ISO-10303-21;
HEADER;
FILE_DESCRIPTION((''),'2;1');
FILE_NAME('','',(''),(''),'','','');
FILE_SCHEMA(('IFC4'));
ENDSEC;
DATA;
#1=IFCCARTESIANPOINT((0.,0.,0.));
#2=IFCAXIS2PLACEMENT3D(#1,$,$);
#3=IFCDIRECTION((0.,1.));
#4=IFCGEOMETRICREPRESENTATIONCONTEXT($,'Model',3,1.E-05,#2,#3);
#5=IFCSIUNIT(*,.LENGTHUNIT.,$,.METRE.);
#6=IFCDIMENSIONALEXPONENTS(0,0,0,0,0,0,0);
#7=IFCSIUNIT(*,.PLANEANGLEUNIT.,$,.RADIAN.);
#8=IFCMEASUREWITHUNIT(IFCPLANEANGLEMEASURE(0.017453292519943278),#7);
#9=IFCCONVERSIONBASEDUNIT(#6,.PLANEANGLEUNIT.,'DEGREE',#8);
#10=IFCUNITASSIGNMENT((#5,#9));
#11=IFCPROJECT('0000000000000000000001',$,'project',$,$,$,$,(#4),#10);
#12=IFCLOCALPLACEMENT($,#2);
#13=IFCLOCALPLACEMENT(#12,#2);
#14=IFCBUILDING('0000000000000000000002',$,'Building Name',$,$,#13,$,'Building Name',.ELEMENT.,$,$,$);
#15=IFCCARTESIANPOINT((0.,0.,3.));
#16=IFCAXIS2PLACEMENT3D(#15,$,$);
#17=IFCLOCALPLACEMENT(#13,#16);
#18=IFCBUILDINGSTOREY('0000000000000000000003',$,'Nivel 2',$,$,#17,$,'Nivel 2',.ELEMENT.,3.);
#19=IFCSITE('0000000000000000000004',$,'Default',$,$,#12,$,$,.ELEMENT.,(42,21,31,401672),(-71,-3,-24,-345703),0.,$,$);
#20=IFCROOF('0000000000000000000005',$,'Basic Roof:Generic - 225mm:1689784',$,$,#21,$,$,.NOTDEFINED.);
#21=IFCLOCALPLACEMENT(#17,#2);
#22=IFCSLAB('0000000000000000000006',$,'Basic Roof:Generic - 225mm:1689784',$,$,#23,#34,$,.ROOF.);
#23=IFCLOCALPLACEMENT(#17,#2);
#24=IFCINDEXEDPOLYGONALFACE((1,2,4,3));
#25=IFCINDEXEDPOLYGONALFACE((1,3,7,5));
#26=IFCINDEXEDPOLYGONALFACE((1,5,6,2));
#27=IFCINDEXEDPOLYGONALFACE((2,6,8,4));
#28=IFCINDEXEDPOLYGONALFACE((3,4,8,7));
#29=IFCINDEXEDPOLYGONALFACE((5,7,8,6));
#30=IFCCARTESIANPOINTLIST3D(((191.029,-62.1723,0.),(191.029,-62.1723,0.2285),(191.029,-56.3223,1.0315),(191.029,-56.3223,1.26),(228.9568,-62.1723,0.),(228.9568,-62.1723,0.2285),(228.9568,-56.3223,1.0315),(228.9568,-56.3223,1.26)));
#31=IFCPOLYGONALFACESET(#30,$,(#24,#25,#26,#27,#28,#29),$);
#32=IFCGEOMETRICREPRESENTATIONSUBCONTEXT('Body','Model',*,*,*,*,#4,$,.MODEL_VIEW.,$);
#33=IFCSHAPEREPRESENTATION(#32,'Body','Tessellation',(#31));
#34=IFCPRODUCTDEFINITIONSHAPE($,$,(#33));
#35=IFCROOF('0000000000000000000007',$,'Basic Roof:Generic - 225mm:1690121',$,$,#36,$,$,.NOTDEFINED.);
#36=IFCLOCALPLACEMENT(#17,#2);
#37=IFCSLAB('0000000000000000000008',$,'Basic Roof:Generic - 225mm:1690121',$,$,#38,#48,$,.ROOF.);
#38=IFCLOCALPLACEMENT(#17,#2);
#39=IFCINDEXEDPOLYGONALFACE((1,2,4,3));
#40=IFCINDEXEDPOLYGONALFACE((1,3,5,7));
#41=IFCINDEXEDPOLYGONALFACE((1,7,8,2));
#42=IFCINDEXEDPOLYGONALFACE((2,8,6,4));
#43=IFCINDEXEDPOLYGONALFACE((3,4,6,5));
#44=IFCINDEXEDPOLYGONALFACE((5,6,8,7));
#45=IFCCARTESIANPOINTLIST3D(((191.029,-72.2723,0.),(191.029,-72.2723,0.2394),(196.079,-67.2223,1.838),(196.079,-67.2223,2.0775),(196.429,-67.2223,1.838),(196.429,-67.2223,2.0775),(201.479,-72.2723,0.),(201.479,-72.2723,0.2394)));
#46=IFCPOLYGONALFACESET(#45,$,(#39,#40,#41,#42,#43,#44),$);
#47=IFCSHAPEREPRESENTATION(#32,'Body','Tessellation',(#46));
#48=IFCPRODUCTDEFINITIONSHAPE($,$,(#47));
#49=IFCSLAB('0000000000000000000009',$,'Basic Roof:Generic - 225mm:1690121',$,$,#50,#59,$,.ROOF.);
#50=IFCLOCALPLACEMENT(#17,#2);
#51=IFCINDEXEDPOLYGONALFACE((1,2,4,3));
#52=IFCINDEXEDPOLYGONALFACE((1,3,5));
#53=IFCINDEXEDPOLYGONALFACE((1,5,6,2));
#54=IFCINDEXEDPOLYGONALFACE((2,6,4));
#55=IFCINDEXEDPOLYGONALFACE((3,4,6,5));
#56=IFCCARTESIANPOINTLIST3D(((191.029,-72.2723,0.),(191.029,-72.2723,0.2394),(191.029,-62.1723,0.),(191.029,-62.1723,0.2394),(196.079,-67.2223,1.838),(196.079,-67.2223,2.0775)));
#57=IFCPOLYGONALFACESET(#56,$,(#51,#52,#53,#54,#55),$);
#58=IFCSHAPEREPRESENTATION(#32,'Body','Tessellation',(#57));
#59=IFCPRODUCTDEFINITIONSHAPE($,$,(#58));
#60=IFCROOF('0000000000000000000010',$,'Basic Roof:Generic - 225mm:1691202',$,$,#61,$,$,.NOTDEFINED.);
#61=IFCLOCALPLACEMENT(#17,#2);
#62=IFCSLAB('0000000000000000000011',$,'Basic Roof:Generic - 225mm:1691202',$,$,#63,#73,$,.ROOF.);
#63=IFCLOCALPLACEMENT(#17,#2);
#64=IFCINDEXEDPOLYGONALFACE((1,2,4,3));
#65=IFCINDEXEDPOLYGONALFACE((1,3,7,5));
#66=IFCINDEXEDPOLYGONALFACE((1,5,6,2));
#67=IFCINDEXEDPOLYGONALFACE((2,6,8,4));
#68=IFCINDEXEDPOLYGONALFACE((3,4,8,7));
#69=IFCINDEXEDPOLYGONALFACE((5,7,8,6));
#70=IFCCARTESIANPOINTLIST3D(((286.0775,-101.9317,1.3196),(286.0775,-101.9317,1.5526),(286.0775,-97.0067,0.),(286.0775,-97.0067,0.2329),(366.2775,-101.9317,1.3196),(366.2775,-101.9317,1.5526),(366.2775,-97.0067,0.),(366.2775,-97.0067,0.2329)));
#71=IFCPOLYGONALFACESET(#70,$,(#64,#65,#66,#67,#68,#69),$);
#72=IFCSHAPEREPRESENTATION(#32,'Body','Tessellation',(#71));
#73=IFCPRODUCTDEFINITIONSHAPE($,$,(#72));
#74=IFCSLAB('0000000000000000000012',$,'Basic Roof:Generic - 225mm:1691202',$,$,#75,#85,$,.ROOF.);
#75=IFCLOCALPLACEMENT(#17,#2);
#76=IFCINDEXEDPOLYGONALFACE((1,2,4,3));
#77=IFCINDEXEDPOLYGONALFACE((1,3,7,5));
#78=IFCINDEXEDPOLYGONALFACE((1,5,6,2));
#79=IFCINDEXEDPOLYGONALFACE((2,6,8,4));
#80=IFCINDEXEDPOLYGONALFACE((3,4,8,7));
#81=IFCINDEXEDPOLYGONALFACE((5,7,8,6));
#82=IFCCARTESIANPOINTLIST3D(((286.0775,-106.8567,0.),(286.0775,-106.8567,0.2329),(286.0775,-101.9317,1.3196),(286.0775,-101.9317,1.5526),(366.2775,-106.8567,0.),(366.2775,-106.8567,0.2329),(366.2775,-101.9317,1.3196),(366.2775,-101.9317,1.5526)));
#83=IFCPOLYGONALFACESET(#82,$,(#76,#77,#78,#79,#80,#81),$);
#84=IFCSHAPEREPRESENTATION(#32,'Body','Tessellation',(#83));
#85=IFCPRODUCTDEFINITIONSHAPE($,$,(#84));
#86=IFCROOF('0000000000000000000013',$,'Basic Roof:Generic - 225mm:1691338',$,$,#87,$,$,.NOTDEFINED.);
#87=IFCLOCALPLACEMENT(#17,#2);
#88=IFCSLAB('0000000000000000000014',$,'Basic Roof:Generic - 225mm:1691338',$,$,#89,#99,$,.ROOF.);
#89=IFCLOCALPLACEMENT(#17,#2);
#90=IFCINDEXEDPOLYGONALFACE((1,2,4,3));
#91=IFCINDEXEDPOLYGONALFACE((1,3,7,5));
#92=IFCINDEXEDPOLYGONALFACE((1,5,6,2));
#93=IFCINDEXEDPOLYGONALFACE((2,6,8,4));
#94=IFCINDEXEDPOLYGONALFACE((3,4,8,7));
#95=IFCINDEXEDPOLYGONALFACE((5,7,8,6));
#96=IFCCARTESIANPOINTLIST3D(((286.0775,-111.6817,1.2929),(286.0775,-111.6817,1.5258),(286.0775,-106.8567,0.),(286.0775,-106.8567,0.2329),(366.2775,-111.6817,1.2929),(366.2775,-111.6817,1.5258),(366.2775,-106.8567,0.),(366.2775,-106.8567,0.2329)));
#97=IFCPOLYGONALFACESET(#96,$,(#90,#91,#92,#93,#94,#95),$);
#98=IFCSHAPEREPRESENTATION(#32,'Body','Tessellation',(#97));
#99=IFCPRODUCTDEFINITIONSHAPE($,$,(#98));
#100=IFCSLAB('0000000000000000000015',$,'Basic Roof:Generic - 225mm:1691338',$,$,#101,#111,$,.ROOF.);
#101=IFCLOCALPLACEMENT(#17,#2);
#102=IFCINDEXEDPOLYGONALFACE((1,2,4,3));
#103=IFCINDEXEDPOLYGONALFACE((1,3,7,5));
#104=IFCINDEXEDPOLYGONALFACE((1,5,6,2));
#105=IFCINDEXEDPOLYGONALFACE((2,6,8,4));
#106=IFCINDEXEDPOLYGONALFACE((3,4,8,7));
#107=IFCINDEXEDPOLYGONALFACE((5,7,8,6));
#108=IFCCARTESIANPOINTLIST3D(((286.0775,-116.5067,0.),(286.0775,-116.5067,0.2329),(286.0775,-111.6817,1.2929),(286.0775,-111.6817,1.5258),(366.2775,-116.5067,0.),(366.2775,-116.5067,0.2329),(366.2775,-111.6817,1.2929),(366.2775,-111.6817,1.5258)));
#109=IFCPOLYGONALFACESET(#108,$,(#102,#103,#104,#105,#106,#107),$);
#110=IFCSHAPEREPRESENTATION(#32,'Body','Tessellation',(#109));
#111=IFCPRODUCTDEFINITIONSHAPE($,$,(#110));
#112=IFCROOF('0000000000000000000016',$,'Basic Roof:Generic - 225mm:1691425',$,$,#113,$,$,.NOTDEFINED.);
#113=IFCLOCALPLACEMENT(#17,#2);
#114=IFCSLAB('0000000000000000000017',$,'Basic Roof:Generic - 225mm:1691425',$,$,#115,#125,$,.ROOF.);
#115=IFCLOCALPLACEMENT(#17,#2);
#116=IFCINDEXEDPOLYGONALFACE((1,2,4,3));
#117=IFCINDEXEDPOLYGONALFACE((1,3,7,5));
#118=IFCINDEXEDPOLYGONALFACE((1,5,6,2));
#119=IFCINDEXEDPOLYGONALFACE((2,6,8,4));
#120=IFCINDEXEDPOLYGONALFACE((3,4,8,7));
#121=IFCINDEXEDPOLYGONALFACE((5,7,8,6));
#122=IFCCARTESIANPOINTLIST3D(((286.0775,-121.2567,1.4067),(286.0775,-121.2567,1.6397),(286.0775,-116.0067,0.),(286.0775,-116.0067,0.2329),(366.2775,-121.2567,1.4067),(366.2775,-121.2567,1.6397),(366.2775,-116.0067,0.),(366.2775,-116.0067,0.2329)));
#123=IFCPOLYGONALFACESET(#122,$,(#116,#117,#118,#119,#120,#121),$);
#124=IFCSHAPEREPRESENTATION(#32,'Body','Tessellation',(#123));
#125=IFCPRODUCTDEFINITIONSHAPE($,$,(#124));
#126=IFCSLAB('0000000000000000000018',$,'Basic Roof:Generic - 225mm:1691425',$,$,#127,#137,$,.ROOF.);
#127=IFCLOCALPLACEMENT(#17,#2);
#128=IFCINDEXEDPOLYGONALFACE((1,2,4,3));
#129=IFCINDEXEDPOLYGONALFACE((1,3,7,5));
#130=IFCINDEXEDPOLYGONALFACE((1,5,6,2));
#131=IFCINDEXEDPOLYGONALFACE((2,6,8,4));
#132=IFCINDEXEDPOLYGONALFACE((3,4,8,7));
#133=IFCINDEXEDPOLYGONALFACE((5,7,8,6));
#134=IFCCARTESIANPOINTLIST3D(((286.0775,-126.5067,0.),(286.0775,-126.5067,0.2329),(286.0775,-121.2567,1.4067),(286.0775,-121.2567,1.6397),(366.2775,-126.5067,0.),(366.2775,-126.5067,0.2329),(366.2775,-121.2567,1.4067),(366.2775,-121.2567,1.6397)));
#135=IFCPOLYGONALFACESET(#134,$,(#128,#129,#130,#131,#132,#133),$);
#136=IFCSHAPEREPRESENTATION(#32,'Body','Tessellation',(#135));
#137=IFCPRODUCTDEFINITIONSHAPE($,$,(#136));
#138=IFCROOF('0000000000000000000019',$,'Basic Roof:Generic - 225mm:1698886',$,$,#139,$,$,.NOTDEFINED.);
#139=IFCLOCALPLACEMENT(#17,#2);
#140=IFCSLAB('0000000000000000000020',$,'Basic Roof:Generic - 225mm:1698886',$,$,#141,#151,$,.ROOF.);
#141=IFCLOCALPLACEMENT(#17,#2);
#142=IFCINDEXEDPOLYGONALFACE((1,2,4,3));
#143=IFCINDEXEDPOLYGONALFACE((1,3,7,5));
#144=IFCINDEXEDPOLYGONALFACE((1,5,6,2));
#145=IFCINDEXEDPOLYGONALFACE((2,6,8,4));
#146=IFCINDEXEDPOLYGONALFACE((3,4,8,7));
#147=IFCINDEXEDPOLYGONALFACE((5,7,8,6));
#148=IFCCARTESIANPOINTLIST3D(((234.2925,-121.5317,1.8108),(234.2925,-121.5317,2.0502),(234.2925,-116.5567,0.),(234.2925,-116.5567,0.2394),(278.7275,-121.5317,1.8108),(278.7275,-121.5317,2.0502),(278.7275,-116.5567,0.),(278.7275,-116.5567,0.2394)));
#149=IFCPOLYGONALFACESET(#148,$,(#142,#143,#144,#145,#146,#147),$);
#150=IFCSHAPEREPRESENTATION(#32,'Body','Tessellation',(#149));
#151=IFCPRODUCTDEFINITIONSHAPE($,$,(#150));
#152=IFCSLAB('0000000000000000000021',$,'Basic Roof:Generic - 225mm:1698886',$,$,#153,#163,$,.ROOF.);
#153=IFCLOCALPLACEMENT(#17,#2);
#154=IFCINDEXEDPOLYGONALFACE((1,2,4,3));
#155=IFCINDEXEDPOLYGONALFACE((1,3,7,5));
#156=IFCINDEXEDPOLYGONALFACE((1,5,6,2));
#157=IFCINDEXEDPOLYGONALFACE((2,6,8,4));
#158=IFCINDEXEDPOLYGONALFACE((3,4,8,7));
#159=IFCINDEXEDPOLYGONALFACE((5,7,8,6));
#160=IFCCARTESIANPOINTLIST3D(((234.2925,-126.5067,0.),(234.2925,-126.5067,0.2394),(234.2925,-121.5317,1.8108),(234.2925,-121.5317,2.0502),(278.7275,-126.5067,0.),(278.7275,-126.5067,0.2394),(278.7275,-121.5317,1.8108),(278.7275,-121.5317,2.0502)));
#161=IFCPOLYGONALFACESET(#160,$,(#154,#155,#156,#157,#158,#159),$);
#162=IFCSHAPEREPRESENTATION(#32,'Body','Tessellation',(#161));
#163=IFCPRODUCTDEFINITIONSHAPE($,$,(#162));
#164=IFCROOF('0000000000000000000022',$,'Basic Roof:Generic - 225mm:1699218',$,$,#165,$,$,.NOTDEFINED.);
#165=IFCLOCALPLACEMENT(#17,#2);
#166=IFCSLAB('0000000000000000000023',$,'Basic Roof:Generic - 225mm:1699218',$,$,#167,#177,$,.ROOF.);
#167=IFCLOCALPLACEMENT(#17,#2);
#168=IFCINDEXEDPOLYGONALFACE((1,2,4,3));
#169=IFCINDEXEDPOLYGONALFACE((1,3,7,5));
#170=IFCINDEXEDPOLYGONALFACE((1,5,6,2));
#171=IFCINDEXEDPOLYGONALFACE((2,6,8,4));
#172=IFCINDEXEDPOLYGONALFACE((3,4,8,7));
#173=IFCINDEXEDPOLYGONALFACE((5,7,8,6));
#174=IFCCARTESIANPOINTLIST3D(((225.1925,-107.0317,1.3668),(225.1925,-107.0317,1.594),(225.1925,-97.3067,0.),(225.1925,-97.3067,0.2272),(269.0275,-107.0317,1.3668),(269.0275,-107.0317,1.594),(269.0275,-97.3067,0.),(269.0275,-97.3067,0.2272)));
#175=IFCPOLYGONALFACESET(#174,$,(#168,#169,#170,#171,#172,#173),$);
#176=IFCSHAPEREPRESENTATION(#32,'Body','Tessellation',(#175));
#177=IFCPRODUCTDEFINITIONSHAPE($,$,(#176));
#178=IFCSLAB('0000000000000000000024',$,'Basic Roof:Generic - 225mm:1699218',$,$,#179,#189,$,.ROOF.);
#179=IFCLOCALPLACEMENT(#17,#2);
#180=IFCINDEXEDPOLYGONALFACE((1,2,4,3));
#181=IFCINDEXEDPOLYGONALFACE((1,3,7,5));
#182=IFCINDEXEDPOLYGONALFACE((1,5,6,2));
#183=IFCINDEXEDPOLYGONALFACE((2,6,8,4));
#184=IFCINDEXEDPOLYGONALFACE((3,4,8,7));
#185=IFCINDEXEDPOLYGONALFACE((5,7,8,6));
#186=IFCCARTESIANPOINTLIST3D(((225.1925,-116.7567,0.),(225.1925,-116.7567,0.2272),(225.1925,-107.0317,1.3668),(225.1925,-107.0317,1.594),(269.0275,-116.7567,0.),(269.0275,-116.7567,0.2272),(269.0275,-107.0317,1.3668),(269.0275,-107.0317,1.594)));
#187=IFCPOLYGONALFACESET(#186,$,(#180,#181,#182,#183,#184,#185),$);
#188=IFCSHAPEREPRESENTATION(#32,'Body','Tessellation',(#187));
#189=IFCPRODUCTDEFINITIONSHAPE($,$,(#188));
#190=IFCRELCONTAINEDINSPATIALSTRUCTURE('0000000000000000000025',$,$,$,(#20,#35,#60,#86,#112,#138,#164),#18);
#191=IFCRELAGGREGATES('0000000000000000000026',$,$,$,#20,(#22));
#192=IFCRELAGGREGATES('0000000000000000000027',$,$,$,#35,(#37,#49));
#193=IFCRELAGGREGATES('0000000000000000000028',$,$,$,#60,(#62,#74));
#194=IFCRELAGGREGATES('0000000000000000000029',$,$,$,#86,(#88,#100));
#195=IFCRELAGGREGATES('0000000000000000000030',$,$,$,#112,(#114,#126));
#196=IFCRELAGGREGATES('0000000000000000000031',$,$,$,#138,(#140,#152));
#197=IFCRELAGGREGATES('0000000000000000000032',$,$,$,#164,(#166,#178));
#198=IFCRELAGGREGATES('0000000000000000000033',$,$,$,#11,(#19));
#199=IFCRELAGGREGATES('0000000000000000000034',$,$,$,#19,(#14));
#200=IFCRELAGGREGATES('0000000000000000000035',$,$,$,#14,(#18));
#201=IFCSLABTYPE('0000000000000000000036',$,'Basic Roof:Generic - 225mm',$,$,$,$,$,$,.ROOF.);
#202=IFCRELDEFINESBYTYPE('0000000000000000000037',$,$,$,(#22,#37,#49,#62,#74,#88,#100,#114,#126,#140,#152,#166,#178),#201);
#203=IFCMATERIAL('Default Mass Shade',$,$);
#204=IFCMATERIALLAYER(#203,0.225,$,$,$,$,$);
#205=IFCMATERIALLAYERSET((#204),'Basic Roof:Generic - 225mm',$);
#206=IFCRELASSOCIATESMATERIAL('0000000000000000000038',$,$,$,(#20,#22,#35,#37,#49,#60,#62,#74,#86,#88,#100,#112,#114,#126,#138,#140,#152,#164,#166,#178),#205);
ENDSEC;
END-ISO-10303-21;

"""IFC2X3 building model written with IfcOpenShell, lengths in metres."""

from ifc_helpers import new_model, entity, si_unit, converted_unit, direction, frame, frame_2d, origin, place, context, subcontext, project, spatial, polyline, rectangle, outline, extrude, material, layer, layer_set, type_object, element, aggregate, save


model = new_model("IFC2X3")

# Units and contexts
model_context = context("Model", 3, precision=1e-05, world=origin(), true_north=direction((0.0, 1.0)))
body_context = subcontext(model_context, "Body", "Model", "MODEL_VIEW")
ifc_project = project(units=[si_unit("LENGTHUNIT", "METRE"), converted_unit("PLANEANGLEUNIT", "DEGREE", entity("IfcPlaneAngleMeasure", 0.017453292519943278), si_unit("PLANEANGLEUNIT", "RADIAN"), dimensions=[0, 0, 0, 0, 0, 0, 0])], contexts=[model_context])

# Site, building, storey
site_placement = place(None, origin())
site = spatial("IfcSite", under=ifc_project, at=site_placement, Name="Default", CompositionType="ELEMENT", RefLatitude=(42, 21, 31, 401672), RefLongitude=(-71, -3, -24, -345703), RefElevation=0.0)
building_placement = place(site_placement, origin())
building = spatial("IfcBuilding", under=site, at=building_placement, Name="Building Name", LongName="Building Name", CompositionType="ELEMENT")
storey_placement = place(building_placement, frame((0.0, 0.0, 3.0)))
storey = spatial("IfcBuildingStorey", under=building, at=storey_placement, Name="Nivel 2", LongName="Nivel 2", CompositionType="ELEMENT", Elevation=3.0)

# Shared definitions
ifc_material = material(Name="Default Mass Shade")
ifc_layer = layer(ifc_material, 0.225)
ifc_layer_set = layer_set([ifc_layer], Name="Basic Roof:Generic - 225mm")
slab_type = type_object("IfcSlabType", Name="Basic Roof:Generic - 225mm", PredefinedType="ROOF")

# Roofs, slabs
roof_1_placement = place(storey_placement, frame((191.029, -62.1723, 0.0)))
roof_1 = element("IfcRoof", 1, at=roof_1_placement, inside=storey, material=ifc_layer_set, Name="Basic Roof:Generic - 225mm:1689784", ShapeType="NOTDEFINED")
slab_1_placement = place(roof_1_placement, origin())
slab_1 = element("IfcSlab", 2, at=slab_1_placement, type_object=slab_type, material=ifc_layer_set, Name="Basic Roof:Generic - 225mm:1689784", PredefinedType="ROOF", context=body_context, shape_type="SweptSolid", body=[
    extrude(rectangle(XDim=5.9402, YDim=37.9278, at=frame_2d((0.0, 0.0), x_axis=(0.0, 1.0))), frame((18.9639, 2.925, 0.5158), z_axis=(0.0, -0.173648, 0.984808), x_axis=(1.0, 0.0, 0.0)), (0.0, 0.173648, 0.984808), 0.2285),
])
aggregate(roof_1, [slab_1])
roof_2_placement = place(storey_placement, frame((191.029, -72.2723, 0.0)))
roof_2 = element("IfcRoof", 3, at=roof_2_placement, inside=storey, material=ifc_layer_set, Name="Basic Roof:Generic - 225mm:1690121", ShapeType="NOTDEFINED")
slab_2_placement = place(roof_2_placement, origin())
slab_2 = element("IfcSlab", 4, at=slab_2_placement, type_object=slab_type, material=ifc_layer_set, Name="Basic Roof:Generic - 225mm:1690121", PredefinedType="ROOF", context=body_context, shape_type="SweptSolid", body=[
    extrude(outline(polyline([(0.175, 2.687), (-0.175, 2.687), (-5.225, -2.687), (5.225, -2.687), (0.175, 2.687)])), frame((5.225, 2.525, 0.919), z_axis=(0.0, -0.34202, 0.939693), x_axis=(1.0, 0.0, 0.0)), (0.0, 0.34202, 0.939693), 0.2394),
])
slab_3_placement = place(roof_2_placement, origin())
slab_3 = element("IfcSlab", 5, at=slab_3_placement, type_object=slab_type, material=ifc_layer_set, Name="Basic Roof:Generic - 225mm:1690121", PredefinedType="ROOF", context=body_context, shape_type="SweptSolid", body=[
    extrude(outline(polyline([(-2.687, 5.05), (-2.687, -5.05), (2.687, 0.0), (-2.687, 5.05)])), frame((2.525, 5.05, 0.919), z_axis=(-0.34202, 0.0, 0.939693), x_axis=(0.939693, 0.0, 0.34202)), (0.34202, 0.0, 0.939693), 0.2394),
])
aggregate(roof_2, [slab_2, slab_3])
roof_3_placement = place(storey_placement, frame((286.0775, -106.8567, 0.0)))
roof_3 = element("IfcRoof", 6, at=roof_3_placement, inside=storey, material=ifc_layer_set, Name="Basic Roof:Generic - 225mm:1691202", ShapeType="NOTDEFINED")
slab_4_placement = place(roof_3_placement, origin())
slab_4 = element("IfcSlab", 7, at=slab_4_placement, type_object=slab_type, material=ifc_layer_set, Name="Basic Roof:Generic - 225mm:1691202", PredefinedType="ROOF", context=body_context, shape_type="SweptSolid", body=[
    extrude(rectangle(XDim=80.2, YDim=5.0987, at=frame_2d((0.0, 0.0), x_axis=(1.0, 0.0))), frame((40.1, 7.3875, 0.6598), z_axis=(0.0, 0.258819, 0.965926), x_axis=(1.0, 0.0, 0.0)), (0.0, -0.258819, 0.965926), 0.2329),
])
slab_5_placement = place(roof_3_placement, origin())
slab_5 = element("IfcSlab", 8, at=slab_5_placement, type_object=slab_type, material=ifc_layer_set, Name="Basic Roof:Generic - 225mm:1691202", PredefinedType="ROOF", context=body_context, shape_type="SweptSolid", body=[
    extrude(rectangle(XDim=5.0987, YDim=80.2, at=frame_2d((0.0, 0.0), x_axis=(0.0, 1.0))), frame((40.1, 2.4625, 0.6598), z_axis=(0.0, -0.258819, 0.965926), x_axis=(1.0, 0.0, 0.0)), (0.0, 0.258819, 0.965926), 0.2329),
])
aggregate(roof_3, [slab_4, slab_5])
roof_4_placement = place(storey_placement, frame((286.0775, -116.5067, 0.0)))
roof_4 = element("IfcRoof", 9, at=roof_4_placement, inside=storey, material=ifc_layer_set, Name="Basic Roof:Generic - 225mm:1691338", ShapeType="NOTDEFINED")
slab_6_placement = place(roof_4_placement, origin())
slab_6 = element("IfcSlab", 10, at=slab_6_placement, type_object=slab_type, material=ifc_layer_set, Name="Basic Roof:Generic - 225mm:1691338", PredefinedType="ROOF", context=body_context, shape_type="SweptSolid", body=[
    extrude(rectangle(XDim=80.2, YDim=4.9952, at=frame_2d((0.0, 0.0), x_axis=(1.0, 0.0))), frame((40.1, 7.2375, 0.6464), z_axis=(0.0, 0.258819, 0.965926), x_axis=(1.0, 0.0, 0.0)), (0.0, -0.258819, 0.965926), 0.2329),
])
slab_7_placement = place(roof_4_placement, origin())
slab_7 = element("IfcSlab", 11, at=slab_7_placement, type_object=slab_type, material=ifc_layer_set, Name="Basic Roof:Generic - 225mm:1691338", PredefinedType="ROOF", context=body_context, shape_type="SweptSolid", body=[
    extrude(rectangle(XDim=4.9952, YDim=80.2, at=frame_2d((0.0, 0.0), x_axis=(0.0, 1.0))), frame((40.1, 2.4125, 0.6464), z_axis=(0.0, -0.258819, 0.965926), x_axis=(1.0, 0.0, 0.0)), (0.0, 0.258819, 0.965926), 0.2329),
])
aggregate(roof_4, [slab_6, slab_7])
roof_5_placement = place(storey_placement, frame((286.0775, -126.5067, 0.0)))
roof_5 = element("IfcRoof", 12, at=roof_5_placement, inside=storey, material=ifc_layer_set, Name="Basic Roof:Generic - 225mm:1691425", ShapeType="NOTDEFINED")
slab_8_placement = place(roof_5_placement, origin())
slab_8 = element("IfcSlab", 13, at=slab_8_placement, type_object=slab_type, material=ifc_layer_set, Name="Basic Roof:Generic - 225mm:1691425", PredefinedType="ROOF", context=body_context, shape_type="SweptSolid", body=[
    extrude(rectangle(XDim=80.2, YDim=5.4352, at=frame_2d((0.0, 0.0), x_axis=(1.0, 0.0))), frame((40.1, 7.875, 0.7034), z_axis=(0.0, 0.258819, 0.965926), x_axis=(1.0, 0.0, 0.0)), (0.0, -0.258819, 0.965926), 0.2329),
])
slab_9_placement = place(roof_5_placement, origin())
slab_9 = element("IfcSlab", 14, at=slab_9_placement, type_object=slab_type, material=ifc_layer_set, Name="Basic Roof:Generic - 225mm:1691425", PredefinedType="ROOF", context=body_context, shape_type="SweptSolid", body=[
    extrude(rectangle(XDim=5.4352, YDim=80.2, at=frame_2d((0.0, 0.0), x_axis=(0.0, 1.0))), frame((40.1, 2.625, 0.7034), z_axis=(0.0, -0.258819, 0.965926), x_axis=(1.0, 0.0, 0.0)), (0.0, 0.258819, 0.965926), 0.2329),
])
aggregate(roof_5, [slab_8, slab_9])
roof_6_placement = place(storey_placement, frame((234.2925, -126.5067, 0.0)))
roof_6 = element("IfcRoof", 15, at=roof_6_placement, inside=storey, material=ifc_layer_set, Name="Basic Roof:Generic - 225mm:1698886", ShapeType="NOTDEFINED")
slab_10_placement = place(roof_6_placement, origin())
slab_10 = element("IfcSlab", 16, at=slab_10_placement, type_object=slab_type, material=ifc_layer_set, Name="Basic Roof:Generic - 225mm:1698886", PredefinedType="ROOF", context=body_context, shape_type="SweptSolid", body=[
    extrude(rectangle(XDim=5.2943, YDim=44.435, at=frame_2d((0.0, 0.0), x_axis=(0.0, -1.0))), frame((22.2175, 7.4625, 0.9054), z_axis=(0.0, 0.34202, 0.939693), x_axis=(1.0, 0.0, 0.0)), (0.0, -0.34202, 0.939693), 0.2394),
])
slab_11_placement = place(roof_6_placement, origin())
slab_11 = element("IfcSlab", 17, at=slab_11_placement, type_object=slab_type, material=ifc_layer_set, Name="Basic Roof:Generic - 225mm:1698886", PredefinedType="ROOF", context=body_context, shape_type="SweptSolid", body=[
    extrude(rectangle(XDim=44.435, YDim=5.2943, at=frame_2d((0.0, 0.0), x_axis=(-1.0, 0.0))), frame((22.2175, 2.4875, 0.9054), z_axis=(0.0, -0.34202, 0.939693), x_axis=(1.0, 0.0, 0.0)), (0.0, 0.34202, 0.939693), 0.2394),
])
aggregate(roof_6, [slab_10, slab_11])
roof_7_placement = place(storey_placement, frame((225.1925, -116.7567, 0.0)))
roof_7 = element("IfcRoof", 18, at=roof_7_placement, inside=storey, material=ifc_layer_set, Name="Basic Roof:Generic - 225mm:1699218", ShapeType="NOTDEFINED")
slab_12_placement = place(roof_7_placement, origin())
slab_12 = element("IfcSlab", 19, at=slab_12_placement, type_object=slab_type, material=ifc_layer_set, Name="Basic Roof:Generic - 225mm:1699218", PredefinedType="ROOF", context=body_context, shape_type="SweptSolid", body=[
    extrude(rectangle(XDim=9.8206, YDim=43.835, at=frame_2d((0.0, 0.0), x_axis=(0.0, -1.0))), frame((21.9175, 14.5875, 0.6834), z_axis=(0.0, 0.139173, 0.990268), x_axis=(1.0, 0.0, 0.0)), (0.0, -0.139173, 0.990268), 0.2272),
])
slab_13_placement = place(roof_7_placement, origin())
slab_13 = element("IfcSlab", 20, at=slab_13_placement, type_object=slab_type, material=ifc_layer_set, Name="Basic Roof:Generic - 225mm:1699218", PredefinedType="ROOF", context=body_context, shape_type="SweptSolid", body=[
    extrude(rectangle(XDim=43.835, YDim=9.8206, at=frame_2d((0.0, 0.0), x_axis=(-1.0, 0.0))), frame((21.9175, 4.8625, 0.6834), z_axis=(0.0, -0.139173, 0.990268), x_axis=(1.0, 0.0, 0.0)), (0.0, 0.139173, 0.990268), 0.2272),
])
aggregate(roof_7, [slab_12, slab_13])

save(model, "model.ifc")
